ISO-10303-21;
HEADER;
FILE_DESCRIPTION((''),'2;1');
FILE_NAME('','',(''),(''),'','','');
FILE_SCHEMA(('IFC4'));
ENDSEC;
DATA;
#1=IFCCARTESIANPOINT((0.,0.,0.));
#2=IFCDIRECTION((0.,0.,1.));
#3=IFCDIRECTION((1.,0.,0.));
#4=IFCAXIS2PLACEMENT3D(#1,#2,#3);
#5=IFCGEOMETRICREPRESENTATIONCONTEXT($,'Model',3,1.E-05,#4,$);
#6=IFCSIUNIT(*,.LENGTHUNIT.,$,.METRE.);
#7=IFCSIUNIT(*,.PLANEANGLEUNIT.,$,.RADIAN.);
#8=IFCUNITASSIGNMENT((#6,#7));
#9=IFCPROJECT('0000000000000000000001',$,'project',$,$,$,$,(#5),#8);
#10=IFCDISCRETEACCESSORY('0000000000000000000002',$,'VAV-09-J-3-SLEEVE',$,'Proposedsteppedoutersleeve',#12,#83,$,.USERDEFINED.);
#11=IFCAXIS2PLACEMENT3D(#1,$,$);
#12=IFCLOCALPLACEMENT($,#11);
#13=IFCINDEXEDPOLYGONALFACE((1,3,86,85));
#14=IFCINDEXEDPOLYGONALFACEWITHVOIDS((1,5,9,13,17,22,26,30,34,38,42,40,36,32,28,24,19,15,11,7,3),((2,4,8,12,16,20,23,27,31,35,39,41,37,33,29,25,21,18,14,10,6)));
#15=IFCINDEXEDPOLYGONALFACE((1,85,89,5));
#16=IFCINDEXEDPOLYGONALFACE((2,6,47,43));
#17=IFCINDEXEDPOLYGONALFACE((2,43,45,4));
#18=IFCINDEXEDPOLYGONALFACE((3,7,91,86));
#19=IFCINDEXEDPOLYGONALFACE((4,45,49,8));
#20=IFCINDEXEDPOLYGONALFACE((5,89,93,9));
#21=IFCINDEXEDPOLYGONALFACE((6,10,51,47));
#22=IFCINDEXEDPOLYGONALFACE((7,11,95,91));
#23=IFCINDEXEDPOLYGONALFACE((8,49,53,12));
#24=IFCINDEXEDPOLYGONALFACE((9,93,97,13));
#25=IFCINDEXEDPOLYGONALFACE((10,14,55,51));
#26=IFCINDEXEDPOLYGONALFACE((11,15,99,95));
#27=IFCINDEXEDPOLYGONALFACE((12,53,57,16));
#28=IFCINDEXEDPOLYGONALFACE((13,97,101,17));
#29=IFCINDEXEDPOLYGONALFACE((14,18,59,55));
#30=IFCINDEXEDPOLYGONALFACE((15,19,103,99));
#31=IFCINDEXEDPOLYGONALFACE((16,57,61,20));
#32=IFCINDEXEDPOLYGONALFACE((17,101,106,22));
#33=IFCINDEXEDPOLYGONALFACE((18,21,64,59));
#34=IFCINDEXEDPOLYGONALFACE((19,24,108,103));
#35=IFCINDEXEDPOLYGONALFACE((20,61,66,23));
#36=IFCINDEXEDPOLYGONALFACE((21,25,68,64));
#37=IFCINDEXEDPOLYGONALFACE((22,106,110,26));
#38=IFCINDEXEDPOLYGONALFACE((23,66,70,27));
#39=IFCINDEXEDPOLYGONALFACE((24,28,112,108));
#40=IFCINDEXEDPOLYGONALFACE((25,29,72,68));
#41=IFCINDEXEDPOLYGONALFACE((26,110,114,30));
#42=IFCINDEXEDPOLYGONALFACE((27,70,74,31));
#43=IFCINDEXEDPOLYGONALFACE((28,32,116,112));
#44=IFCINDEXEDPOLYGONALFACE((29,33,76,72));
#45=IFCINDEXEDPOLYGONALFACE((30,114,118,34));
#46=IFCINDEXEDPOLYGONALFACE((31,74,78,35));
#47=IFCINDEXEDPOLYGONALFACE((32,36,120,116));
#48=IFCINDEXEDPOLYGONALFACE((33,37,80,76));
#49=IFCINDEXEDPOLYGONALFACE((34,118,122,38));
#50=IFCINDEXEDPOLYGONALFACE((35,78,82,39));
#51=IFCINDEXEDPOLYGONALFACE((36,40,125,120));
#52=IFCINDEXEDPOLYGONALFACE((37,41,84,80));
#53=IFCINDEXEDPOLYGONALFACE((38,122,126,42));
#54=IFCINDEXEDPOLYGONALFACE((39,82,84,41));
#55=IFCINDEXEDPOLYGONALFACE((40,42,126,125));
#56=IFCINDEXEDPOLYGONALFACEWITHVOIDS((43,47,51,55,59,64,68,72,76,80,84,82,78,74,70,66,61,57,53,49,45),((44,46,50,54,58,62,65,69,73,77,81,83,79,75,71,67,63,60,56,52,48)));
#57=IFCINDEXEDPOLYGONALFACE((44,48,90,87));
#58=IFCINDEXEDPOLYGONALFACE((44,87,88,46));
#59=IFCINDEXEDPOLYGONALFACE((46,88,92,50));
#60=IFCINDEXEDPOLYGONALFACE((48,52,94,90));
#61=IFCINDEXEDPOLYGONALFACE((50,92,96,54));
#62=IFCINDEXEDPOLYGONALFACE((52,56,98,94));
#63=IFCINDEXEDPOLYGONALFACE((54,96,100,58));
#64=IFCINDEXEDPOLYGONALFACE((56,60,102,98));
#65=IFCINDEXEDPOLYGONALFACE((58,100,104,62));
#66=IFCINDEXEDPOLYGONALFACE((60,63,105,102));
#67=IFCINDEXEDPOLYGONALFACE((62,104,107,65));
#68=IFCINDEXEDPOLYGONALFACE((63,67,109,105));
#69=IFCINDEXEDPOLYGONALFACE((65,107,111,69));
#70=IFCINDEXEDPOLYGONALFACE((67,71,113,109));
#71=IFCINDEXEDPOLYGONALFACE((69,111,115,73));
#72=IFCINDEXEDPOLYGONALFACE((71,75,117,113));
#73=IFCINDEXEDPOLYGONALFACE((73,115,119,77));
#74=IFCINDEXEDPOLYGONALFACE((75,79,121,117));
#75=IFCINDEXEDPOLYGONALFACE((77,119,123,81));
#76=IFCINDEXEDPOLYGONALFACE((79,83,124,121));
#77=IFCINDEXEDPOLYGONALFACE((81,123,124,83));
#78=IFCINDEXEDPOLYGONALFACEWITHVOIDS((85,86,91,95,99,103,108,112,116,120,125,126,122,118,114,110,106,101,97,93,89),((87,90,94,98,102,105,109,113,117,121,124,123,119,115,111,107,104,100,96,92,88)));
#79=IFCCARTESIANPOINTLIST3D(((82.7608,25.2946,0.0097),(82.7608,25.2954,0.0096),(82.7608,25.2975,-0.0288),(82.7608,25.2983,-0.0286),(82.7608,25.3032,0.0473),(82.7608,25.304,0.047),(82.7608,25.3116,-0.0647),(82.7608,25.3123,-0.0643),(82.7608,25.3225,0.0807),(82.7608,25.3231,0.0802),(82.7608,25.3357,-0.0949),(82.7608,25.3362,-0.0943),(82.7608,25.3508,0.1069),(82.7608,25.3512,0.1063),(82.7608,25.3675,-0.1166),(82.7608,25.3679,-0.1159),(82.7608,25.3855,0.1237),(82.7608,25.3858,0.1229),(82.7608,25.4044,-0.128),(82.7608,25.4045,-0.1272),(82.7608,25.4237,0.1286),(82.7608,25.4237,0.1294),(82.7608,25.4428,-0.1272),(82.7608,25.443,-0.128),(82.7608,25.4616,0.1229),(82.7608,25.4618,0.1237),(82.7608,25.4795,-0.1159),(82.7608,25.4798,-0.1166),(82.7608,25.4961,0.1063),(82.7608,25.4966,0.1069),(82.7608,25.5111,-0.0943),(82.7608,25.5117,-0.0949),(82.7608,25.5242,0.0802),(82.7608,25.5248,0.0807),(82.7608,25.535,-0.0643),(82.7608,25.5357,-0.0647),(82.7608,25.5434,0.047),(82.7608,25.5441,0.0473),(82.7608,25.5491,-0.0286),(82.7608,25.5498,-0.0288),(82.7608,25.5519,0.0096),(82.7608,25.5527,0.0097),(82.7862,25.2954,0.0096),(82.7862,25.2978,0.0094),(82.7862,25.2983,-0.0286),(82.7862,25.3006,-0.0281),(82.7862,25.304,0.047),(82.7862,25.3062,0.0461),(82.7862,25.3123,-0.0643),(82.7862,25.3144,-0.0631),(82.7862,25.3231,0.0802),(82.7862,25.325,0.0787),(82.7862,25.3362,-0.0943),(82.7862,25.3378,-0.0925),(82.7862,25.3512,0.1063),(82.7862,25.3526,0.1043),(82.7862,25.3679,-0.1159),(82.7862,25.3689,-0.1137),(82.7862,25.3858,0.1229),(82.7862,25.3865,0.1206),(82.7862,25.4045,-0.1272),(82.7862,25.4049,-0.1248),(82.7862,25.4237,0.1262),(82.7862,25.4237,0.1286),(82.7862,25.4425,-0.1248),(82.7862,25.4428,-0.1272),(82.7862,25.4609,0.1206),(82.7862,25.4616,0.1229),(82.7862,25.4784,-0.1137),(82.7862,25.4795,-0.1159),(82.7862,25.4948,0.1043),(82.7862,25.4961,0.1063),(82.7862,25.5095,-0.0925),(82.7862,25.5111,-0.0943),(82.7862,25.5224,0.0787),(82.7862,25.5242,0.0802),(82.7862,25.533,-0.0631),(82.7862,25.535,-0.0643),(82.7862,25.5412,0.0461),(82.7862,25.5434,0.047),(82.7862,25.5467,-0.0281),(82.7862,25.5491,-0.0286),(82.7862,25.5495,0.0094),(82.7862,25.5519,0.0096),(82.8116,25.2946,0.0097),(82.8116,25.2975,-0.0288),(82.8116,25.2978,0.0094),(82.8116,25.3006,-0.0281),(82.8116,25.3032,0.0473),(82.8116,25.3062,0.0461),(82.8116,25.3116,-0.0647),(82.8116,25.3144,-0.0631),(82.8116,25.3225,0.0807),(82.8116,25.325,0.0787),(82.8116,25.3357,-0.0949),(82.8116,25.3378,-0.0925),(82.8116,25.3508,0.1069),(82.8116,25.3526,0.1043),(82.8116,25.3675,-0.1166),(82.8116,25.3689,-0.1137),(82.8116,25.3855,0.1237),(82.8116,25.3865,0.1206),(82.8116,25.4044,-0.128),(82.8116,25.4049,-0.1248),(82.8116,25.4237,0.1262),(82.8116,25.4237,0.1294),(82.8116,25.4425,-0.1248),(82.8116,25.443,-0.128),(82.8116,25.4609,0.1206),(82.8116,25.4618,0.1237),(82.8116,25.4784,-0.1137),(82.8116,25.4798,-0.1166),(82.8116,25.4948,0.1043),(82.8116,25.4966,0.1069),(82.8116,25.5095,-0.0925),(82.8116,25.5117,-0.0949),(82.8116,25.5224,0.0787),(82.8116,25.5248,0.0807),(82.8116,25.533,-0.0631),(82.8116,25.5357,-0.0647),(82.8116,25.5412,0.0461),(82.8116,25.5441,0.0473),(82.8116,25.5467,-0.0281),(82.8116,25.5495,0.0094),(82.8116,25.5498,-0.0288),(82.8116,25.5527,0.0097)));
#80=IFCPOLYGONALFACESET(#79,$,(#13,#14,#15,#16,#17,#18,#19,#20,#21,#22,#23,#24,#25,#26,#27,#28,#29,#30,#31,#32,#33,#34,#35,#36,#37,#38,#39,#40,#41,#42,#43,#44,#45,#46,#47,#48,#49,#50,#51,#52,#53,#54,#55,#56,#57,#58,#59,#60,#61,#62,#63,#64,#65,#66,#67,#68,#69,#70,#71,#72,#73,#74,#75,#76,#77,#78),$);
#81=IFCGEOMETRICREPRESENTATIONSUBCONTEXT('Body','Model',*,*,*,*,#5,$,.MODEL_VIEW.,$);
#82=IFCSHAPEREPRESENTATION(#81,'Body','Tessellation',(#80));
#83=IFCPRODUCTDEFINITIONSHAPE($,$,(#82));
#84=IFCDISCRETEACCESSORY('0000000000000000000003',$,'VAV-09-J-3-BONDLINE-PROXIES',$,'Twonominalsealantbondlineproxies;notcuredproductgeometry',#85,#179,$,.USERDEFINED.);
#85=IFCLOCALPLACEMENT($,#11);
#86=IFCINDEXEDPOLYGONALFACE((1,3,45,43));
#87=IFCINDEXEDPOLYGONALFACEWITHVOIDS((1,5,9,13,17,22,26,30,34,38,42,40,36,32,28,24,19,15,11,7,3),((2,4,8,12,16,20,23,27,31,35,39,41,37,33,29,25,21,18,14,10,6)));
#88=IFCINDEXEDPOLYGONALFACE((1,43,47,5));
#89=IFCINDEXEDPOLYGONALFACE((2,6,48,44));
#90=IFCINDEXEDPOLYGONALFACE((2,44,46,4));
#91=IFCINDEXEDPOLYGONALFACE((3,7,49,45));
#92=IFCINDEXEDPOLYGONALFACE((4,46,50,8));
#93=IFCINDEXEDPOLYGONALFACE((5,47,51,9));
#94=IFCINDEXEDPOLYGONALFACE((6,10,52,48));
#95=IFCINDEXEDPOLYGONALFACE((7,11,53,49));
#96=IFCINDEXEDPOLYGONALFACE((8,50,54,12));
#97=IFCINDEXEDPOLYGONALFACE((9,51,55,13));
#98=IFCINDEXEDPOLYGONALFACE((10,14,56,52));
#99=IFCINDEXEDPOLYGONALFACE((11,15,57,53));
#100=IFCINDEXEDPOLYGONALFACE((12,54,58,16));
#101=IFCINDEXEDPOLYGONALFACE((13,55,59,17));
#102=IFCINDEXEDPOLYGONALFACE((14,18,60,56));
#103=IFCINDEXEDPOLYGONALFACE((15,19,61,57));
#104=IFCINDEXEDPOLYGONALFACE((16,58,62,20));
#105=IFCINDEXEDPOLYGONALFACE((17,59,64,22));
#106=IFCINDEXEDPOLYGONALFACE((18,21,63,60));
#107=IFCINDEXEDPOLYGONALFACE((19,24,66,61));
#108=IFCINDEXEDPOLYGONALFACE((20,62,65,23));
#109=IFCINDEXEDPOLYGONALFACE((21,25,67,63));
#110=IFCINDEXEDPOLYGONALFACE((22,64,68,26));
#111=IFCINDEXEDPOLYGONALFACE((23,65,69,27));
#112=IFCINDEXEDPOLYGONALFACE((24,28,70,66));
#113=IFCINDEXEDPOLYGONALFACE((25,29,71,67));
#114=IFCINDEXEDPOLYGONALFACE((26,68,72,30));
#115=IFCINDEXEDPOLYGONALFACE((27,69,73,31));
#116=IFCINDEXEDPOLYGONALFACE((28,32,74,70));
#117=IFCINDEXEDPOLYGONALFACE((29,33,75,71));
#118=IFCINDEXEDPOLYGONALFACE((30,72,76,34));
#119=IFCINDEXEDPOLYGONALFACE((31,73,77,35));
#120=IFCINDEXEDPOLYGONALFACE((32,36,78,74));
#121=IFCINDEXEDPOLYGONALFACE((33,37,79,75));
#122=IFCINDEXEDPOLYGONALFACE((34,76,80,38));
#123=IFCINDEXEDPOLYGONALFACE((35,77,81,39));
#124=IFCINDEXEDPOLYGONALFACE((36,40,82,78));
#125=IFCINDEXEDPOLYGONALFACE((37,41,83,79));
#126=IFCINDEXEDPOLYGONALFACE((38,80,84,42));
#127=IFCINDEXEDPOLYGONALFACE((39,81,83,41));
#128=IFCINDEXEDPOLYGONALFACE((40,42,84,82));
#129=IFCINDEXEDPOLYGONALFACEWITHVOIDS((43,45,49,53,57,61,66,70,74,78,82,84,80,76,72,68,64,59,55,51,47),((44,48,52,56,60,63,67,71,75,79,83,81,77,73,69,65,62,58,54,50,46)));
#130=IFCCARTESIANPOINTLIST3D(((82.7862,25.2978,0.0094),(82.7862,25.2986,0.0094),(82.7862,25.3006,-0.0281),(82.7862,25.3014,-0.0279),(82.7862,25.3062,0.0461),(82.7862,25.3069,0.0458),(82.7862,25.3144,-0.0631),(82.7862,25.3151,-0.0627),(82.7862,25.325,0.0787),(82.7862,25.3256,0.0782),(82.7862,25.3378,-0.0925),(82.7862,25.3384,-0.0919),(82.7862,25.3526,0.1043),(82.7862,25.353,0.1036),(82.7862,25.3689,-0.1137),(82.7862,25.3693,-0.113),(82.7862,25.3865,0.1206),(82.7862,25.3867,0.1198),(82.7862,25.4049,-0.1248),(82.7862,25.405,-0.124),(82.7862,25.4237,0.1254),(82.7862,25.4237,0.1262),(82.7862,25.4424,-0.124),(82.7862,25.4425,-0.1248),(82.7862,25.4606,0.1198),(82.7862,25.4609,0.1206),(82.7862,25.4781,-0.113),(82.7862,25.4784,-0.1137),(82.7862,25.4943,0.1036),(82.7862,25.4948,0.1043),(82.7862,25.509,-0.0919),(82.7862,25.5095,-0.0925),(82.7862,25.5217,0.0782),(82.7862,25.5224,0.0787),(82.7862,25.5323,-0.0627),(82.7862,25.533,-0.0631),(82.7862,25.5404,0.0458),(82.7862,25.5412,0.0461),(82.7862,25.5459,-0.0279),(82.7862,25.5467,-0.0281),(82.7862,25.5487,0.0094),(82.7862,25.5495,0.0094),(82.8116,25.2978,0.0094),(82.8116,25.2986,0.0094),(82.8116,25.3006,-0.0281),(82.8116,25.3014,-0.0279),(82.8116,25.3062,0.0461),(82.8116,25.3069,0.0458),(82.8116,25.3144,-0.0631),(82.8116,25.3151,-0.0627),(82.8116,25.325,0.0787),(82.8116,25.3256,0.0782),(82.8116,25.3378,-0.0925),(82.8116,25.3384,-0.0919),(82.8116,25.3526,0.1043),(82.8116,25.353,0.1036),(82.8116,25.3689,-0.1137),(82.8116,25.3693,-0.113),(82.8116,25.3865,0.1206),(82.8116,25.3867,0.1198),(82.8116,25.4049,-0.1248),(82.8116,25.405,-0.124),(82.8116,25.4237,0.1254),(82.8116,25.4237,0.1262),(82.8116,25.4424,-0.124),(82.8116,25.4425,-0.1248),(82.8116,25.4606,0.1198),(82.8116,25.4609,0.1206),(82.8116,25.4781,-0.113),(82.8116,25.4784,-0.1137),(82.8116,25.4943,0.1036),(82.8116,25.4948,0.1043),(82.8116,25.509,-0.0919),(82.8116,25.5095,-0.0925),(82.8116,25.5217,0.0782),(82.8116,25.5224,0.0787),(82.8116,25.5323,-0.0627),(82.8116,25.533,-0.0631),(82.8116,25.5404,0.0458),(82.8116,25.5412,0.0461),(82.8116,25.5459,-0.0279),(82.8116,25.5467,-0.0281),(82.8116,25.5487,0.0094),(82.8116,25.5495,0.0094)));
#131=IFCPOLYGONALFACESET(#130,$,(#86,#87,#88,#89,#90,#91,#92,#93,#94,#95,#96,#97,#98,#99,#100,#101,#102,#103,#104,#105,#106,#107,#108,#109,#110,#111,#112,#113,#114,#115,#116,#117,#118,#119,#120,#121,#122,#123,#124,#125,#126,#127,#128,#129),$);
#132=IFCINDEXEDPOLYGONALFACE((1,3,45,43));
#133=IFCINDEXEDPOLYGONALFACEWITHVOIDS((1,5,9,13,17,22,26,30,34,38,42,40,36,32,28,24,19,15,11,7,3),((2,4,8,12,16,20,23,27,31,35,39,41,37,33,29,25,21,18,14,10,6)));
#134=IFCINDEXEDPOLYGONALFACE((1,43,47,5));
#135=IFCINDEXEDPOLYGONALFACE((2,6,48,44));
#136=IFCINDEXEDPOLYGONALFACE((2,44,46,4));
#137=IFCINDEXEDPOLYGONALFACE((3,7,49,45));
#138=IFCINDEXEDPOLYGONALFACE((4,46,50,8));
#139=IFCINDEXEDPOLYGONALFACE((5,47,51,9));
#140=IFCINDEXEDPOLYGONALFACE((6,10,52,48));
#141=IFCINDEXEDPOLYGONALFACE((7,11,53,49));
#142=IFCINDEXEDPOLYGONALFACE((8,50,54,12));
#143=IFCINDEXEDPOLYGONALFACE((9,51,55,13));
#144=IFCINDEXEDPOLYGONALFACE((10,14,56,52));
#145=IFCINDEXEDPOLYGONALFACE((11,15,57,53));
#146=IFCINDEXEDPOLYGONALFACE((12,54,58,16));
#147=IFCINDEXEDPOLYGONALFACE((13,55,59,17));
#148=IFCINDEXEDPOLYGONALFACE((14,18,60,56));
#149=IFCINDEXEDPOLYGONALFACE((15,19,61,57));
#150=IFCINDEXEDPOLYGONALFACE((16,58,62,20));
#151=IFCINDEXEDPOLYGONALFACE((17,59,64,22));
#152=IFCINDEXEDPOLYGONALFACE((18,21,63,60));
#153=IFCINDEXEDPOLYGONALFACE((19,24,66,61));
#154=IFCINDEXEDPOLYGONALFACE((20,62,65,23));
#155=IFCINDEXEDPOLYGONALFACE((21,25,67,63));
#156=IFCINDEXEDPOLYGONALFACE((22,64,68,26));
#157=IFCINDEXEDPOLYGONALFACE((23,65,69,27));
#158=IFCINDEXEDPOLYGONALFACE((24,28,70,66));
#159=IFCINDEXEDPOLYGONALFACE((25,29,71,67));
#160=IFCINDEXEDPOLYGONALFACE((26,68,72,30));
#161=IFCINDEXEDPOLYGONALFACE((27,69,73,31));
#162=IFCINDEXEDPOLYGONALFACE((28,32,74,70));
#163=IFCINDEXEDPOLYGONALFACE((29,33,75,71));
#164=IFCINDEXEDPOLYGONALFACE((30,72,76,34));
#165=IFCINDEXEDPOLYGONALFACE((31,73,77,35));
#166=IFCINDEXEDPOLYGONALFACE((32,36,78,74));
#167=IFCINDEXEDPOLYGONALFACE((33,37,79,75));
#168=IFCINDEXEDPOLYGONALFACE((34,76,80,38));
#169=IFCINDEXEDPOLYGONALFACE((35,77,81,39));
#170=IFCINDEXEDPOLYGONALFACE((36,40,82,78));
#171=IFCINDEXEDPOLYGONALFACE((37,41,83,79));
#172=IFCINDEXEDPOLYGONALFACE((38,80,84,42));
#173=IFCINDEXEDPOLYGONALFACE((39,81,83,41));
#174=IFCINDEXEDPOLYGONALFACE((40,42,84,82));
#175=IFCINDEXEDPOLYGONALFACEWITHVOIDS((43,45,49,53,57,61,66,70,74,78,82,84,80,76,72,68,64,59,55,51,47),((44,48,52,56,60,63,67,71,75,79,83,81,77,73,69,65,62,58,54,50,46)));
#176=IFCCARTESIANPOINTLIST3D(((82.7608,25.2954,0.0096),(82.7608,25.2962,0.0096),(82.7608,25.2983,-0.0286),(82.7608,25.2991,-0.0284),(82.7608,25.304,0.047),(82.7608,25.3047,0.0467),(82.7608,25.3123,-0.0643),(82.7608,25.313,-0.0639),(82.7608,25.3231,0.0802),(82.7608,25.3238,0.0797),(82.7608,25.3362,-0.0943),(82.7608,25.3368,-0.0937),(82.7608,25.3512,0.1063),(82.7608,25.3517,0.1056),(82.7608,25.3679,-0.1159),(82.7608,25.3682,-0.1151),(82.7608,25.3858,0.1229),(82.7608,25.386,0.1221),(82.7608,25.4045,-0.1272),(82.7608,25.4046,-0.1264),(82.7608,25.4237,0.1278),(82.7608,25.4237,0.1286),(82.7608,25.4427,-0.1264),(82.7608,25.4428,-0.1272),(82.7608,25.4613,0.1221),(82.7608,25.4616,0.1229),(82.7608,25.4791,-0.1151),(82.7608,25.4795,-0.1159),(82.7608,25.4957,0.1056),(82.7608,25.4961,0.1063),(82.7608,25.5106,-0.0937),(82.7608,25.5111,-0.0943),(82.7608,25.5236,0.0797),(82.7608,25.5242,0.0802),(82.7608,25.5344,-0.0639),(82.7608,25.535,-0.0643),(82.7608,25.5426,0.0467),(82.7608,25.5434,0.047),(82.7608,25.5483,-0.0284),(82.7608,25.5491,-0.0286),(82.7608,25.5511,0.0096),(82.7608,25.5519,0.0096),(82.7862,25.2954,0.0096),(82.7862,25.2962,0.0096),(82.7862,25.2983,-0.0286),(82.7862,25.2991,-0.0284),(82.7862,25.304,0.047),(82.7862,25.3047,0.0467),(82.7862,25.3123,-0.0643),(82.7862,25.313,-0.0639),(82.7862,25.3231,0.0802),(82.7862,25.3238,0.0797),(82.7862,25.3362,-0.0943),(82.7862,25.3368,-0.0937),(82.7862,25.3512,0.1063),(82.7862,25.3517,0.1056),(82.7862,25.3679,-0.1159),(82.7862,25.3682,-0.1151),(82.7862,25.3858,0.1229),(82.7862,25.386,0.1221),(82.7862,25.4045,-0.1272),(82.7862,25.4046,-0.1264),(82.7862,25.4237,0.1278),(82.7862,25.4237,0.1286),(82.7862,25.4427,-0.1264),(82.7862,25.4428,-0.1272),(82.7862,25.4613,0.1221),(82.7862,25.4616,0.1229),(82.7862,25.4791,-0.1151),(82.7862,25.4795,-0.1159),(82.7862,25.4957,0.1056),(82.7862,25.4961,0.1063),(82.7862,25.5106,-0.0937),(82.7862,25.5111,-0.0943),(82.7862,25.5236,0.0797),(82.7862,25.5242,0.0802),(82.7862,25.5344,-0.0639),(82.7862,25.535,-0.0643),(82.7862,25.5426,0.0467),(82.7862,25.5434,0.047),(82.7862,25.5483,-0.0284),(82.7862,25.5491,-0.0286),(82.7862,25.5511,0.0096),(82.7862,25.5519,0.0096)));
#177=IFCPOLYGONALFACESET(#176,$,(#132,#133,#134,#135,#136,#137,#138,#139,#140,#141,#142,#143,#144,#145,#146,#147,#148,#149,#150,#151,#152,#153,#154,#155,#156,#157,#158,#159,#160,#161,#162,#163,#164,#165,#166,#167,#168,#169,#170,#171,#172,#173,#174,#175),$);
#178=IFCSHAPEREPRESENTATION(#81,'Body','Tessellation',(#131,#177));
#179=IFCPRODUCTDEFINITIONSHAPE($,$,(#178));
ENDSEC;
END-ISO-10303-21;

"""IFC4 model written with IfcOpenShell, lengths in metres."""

from ifc_helpers import new_model, entity, si_unit, frame, origin_with_axes, place, context, subcontext, project, element, save


model = new_model("IFC4")

# Units and contexts
model_context = context("Model", 3, precision=1e-05, world=origin_with_axes())
body_context = subcontext(model_context, "Body", "Model", "MODEL_VIEW")
ifc_project = project(units=[si_unit("LENGTHUNIT", "METRE"), si_unit("PLANEANGLEUNIT", "RADIAN")], contexts=[model_context])

# Discrete accessories
discrete_accessory_1_placement = place(None, frame((82.7862, 25.4237, 0.0), z_axis=(0.0, -1.0, 0.0), x_axis=(0.0, 0.0, 1.0)))
element("IfcDiscreteAccessory", 1, at=discrete_accessory_1_placement, Name="VAV-09-J-3-SLEEVE", ObjectType="Proposedsteppedoutersleeve", PredefinedType="USERDEFINED", context=body_context, shape_type="SweptSolid", body=[
    entity("IfcRevolvedAreaSolid", entity("IfcArbitraryClosedProfileDef", "AREA", None, entity("IfcPolyline", [entity("IfcCartesianPoint", [0.1262, -0.0254]), entity("IfcCartesianPoint", [0.1294, -0.0254]), entity("IfcCartesianPoint", [0.1294, 0.0254]), entity("IfcCartesianPoint", [0.1286, 0.0254]), entity("IfcCartesianPoint", [0.1286, 0.0]), entity("IfcCartesianPoint", [0.1262, 0.0]), entity("IfcCartesianPoint", [0.1262, -0.0254])])), entity("IfcAxis2Placement3D", entity("IfcCartesianPoint", [0.0, 0.0, 0.0])), entity("IfcAxis1Placement", entity("IfcCartesianPoint", [0.0, 0.0, 0.0]), entity("IfcDirection", [0.0, 1.0, 0.0])), 6.283185),
])
discrete_accessory_2_placement = place(None, frame((82.7862, 25.4237, 0.0), z_axis=(0.0, -1.0, 0.0), x_axis=(0.0, 0.0, 1.0)))
element("IfcDiscreteAccessory", 2, at=discrete_accessory_2_placement, Name="VAV-09-J-3-BONDLINE-PROXIES", ObjectType="Twonominalsealantbondlineproxies;notcuredproductgeometry", PredefinedType="USERDEFINED", context=body_context, shape_type="SweptSolid", body=[
    entity("IfcRevolvedAreaSolid", entity("IfcArbitraryClosedProfileDef", "AREA", None, entity("IfcPolyline", [entity("IfcCartesianPoint", [0.1254, -0.0254]), entity("IfcCartesianPoint", [0.1262, -0.0254]), entity("IfcCartesianPoint", [0.1262, 0.0]), entity("IfcCartesianPoint", [0.1254, 0.0]), entity("IfcCartesianPoint", [0.1254, -0.0254])])), entity("IfcAxis2Placement3D", entity("IfcCartesianPoint", [0.0, 0.0, 0.0])), entity("IfcAxis1Placement", entity("IfcCartesianPoint", [0.0, 0.0, 0.0]), entity("IfcDirection", [0.0, 1.0, 0.0])), 6.283185),
    entity("IfcRevolvedAreaSolid", entity("IfcArbitraryClosedProfileDef", "AREA", None, entity("IfcPolyline", [entity("IfcCartesianPoint", [0.1278, 0.0]), entity("IfcCartesianPoint", [0.1286, 0.0]), entity("IfcCartesianPoint", [0.1286, 0.0254]), entity("IfcCartesianPoint", [0.1278, 0.0254]), entity("IfcCartesianPoint", [0.1278, 0.0])])), entity("IfcAxis2Placement3D", entity("IfcCartesianPoint", [0.0, 0.0, 0.0])), entity("IfcAxis1Placement", entity("IfcCartesianPoint", [0.0, 0.0, 0.0]), entity("IfcDirection", [0.0, 1.0, 0.0])), 6.283185),
])

save(model, "model.ifc")
